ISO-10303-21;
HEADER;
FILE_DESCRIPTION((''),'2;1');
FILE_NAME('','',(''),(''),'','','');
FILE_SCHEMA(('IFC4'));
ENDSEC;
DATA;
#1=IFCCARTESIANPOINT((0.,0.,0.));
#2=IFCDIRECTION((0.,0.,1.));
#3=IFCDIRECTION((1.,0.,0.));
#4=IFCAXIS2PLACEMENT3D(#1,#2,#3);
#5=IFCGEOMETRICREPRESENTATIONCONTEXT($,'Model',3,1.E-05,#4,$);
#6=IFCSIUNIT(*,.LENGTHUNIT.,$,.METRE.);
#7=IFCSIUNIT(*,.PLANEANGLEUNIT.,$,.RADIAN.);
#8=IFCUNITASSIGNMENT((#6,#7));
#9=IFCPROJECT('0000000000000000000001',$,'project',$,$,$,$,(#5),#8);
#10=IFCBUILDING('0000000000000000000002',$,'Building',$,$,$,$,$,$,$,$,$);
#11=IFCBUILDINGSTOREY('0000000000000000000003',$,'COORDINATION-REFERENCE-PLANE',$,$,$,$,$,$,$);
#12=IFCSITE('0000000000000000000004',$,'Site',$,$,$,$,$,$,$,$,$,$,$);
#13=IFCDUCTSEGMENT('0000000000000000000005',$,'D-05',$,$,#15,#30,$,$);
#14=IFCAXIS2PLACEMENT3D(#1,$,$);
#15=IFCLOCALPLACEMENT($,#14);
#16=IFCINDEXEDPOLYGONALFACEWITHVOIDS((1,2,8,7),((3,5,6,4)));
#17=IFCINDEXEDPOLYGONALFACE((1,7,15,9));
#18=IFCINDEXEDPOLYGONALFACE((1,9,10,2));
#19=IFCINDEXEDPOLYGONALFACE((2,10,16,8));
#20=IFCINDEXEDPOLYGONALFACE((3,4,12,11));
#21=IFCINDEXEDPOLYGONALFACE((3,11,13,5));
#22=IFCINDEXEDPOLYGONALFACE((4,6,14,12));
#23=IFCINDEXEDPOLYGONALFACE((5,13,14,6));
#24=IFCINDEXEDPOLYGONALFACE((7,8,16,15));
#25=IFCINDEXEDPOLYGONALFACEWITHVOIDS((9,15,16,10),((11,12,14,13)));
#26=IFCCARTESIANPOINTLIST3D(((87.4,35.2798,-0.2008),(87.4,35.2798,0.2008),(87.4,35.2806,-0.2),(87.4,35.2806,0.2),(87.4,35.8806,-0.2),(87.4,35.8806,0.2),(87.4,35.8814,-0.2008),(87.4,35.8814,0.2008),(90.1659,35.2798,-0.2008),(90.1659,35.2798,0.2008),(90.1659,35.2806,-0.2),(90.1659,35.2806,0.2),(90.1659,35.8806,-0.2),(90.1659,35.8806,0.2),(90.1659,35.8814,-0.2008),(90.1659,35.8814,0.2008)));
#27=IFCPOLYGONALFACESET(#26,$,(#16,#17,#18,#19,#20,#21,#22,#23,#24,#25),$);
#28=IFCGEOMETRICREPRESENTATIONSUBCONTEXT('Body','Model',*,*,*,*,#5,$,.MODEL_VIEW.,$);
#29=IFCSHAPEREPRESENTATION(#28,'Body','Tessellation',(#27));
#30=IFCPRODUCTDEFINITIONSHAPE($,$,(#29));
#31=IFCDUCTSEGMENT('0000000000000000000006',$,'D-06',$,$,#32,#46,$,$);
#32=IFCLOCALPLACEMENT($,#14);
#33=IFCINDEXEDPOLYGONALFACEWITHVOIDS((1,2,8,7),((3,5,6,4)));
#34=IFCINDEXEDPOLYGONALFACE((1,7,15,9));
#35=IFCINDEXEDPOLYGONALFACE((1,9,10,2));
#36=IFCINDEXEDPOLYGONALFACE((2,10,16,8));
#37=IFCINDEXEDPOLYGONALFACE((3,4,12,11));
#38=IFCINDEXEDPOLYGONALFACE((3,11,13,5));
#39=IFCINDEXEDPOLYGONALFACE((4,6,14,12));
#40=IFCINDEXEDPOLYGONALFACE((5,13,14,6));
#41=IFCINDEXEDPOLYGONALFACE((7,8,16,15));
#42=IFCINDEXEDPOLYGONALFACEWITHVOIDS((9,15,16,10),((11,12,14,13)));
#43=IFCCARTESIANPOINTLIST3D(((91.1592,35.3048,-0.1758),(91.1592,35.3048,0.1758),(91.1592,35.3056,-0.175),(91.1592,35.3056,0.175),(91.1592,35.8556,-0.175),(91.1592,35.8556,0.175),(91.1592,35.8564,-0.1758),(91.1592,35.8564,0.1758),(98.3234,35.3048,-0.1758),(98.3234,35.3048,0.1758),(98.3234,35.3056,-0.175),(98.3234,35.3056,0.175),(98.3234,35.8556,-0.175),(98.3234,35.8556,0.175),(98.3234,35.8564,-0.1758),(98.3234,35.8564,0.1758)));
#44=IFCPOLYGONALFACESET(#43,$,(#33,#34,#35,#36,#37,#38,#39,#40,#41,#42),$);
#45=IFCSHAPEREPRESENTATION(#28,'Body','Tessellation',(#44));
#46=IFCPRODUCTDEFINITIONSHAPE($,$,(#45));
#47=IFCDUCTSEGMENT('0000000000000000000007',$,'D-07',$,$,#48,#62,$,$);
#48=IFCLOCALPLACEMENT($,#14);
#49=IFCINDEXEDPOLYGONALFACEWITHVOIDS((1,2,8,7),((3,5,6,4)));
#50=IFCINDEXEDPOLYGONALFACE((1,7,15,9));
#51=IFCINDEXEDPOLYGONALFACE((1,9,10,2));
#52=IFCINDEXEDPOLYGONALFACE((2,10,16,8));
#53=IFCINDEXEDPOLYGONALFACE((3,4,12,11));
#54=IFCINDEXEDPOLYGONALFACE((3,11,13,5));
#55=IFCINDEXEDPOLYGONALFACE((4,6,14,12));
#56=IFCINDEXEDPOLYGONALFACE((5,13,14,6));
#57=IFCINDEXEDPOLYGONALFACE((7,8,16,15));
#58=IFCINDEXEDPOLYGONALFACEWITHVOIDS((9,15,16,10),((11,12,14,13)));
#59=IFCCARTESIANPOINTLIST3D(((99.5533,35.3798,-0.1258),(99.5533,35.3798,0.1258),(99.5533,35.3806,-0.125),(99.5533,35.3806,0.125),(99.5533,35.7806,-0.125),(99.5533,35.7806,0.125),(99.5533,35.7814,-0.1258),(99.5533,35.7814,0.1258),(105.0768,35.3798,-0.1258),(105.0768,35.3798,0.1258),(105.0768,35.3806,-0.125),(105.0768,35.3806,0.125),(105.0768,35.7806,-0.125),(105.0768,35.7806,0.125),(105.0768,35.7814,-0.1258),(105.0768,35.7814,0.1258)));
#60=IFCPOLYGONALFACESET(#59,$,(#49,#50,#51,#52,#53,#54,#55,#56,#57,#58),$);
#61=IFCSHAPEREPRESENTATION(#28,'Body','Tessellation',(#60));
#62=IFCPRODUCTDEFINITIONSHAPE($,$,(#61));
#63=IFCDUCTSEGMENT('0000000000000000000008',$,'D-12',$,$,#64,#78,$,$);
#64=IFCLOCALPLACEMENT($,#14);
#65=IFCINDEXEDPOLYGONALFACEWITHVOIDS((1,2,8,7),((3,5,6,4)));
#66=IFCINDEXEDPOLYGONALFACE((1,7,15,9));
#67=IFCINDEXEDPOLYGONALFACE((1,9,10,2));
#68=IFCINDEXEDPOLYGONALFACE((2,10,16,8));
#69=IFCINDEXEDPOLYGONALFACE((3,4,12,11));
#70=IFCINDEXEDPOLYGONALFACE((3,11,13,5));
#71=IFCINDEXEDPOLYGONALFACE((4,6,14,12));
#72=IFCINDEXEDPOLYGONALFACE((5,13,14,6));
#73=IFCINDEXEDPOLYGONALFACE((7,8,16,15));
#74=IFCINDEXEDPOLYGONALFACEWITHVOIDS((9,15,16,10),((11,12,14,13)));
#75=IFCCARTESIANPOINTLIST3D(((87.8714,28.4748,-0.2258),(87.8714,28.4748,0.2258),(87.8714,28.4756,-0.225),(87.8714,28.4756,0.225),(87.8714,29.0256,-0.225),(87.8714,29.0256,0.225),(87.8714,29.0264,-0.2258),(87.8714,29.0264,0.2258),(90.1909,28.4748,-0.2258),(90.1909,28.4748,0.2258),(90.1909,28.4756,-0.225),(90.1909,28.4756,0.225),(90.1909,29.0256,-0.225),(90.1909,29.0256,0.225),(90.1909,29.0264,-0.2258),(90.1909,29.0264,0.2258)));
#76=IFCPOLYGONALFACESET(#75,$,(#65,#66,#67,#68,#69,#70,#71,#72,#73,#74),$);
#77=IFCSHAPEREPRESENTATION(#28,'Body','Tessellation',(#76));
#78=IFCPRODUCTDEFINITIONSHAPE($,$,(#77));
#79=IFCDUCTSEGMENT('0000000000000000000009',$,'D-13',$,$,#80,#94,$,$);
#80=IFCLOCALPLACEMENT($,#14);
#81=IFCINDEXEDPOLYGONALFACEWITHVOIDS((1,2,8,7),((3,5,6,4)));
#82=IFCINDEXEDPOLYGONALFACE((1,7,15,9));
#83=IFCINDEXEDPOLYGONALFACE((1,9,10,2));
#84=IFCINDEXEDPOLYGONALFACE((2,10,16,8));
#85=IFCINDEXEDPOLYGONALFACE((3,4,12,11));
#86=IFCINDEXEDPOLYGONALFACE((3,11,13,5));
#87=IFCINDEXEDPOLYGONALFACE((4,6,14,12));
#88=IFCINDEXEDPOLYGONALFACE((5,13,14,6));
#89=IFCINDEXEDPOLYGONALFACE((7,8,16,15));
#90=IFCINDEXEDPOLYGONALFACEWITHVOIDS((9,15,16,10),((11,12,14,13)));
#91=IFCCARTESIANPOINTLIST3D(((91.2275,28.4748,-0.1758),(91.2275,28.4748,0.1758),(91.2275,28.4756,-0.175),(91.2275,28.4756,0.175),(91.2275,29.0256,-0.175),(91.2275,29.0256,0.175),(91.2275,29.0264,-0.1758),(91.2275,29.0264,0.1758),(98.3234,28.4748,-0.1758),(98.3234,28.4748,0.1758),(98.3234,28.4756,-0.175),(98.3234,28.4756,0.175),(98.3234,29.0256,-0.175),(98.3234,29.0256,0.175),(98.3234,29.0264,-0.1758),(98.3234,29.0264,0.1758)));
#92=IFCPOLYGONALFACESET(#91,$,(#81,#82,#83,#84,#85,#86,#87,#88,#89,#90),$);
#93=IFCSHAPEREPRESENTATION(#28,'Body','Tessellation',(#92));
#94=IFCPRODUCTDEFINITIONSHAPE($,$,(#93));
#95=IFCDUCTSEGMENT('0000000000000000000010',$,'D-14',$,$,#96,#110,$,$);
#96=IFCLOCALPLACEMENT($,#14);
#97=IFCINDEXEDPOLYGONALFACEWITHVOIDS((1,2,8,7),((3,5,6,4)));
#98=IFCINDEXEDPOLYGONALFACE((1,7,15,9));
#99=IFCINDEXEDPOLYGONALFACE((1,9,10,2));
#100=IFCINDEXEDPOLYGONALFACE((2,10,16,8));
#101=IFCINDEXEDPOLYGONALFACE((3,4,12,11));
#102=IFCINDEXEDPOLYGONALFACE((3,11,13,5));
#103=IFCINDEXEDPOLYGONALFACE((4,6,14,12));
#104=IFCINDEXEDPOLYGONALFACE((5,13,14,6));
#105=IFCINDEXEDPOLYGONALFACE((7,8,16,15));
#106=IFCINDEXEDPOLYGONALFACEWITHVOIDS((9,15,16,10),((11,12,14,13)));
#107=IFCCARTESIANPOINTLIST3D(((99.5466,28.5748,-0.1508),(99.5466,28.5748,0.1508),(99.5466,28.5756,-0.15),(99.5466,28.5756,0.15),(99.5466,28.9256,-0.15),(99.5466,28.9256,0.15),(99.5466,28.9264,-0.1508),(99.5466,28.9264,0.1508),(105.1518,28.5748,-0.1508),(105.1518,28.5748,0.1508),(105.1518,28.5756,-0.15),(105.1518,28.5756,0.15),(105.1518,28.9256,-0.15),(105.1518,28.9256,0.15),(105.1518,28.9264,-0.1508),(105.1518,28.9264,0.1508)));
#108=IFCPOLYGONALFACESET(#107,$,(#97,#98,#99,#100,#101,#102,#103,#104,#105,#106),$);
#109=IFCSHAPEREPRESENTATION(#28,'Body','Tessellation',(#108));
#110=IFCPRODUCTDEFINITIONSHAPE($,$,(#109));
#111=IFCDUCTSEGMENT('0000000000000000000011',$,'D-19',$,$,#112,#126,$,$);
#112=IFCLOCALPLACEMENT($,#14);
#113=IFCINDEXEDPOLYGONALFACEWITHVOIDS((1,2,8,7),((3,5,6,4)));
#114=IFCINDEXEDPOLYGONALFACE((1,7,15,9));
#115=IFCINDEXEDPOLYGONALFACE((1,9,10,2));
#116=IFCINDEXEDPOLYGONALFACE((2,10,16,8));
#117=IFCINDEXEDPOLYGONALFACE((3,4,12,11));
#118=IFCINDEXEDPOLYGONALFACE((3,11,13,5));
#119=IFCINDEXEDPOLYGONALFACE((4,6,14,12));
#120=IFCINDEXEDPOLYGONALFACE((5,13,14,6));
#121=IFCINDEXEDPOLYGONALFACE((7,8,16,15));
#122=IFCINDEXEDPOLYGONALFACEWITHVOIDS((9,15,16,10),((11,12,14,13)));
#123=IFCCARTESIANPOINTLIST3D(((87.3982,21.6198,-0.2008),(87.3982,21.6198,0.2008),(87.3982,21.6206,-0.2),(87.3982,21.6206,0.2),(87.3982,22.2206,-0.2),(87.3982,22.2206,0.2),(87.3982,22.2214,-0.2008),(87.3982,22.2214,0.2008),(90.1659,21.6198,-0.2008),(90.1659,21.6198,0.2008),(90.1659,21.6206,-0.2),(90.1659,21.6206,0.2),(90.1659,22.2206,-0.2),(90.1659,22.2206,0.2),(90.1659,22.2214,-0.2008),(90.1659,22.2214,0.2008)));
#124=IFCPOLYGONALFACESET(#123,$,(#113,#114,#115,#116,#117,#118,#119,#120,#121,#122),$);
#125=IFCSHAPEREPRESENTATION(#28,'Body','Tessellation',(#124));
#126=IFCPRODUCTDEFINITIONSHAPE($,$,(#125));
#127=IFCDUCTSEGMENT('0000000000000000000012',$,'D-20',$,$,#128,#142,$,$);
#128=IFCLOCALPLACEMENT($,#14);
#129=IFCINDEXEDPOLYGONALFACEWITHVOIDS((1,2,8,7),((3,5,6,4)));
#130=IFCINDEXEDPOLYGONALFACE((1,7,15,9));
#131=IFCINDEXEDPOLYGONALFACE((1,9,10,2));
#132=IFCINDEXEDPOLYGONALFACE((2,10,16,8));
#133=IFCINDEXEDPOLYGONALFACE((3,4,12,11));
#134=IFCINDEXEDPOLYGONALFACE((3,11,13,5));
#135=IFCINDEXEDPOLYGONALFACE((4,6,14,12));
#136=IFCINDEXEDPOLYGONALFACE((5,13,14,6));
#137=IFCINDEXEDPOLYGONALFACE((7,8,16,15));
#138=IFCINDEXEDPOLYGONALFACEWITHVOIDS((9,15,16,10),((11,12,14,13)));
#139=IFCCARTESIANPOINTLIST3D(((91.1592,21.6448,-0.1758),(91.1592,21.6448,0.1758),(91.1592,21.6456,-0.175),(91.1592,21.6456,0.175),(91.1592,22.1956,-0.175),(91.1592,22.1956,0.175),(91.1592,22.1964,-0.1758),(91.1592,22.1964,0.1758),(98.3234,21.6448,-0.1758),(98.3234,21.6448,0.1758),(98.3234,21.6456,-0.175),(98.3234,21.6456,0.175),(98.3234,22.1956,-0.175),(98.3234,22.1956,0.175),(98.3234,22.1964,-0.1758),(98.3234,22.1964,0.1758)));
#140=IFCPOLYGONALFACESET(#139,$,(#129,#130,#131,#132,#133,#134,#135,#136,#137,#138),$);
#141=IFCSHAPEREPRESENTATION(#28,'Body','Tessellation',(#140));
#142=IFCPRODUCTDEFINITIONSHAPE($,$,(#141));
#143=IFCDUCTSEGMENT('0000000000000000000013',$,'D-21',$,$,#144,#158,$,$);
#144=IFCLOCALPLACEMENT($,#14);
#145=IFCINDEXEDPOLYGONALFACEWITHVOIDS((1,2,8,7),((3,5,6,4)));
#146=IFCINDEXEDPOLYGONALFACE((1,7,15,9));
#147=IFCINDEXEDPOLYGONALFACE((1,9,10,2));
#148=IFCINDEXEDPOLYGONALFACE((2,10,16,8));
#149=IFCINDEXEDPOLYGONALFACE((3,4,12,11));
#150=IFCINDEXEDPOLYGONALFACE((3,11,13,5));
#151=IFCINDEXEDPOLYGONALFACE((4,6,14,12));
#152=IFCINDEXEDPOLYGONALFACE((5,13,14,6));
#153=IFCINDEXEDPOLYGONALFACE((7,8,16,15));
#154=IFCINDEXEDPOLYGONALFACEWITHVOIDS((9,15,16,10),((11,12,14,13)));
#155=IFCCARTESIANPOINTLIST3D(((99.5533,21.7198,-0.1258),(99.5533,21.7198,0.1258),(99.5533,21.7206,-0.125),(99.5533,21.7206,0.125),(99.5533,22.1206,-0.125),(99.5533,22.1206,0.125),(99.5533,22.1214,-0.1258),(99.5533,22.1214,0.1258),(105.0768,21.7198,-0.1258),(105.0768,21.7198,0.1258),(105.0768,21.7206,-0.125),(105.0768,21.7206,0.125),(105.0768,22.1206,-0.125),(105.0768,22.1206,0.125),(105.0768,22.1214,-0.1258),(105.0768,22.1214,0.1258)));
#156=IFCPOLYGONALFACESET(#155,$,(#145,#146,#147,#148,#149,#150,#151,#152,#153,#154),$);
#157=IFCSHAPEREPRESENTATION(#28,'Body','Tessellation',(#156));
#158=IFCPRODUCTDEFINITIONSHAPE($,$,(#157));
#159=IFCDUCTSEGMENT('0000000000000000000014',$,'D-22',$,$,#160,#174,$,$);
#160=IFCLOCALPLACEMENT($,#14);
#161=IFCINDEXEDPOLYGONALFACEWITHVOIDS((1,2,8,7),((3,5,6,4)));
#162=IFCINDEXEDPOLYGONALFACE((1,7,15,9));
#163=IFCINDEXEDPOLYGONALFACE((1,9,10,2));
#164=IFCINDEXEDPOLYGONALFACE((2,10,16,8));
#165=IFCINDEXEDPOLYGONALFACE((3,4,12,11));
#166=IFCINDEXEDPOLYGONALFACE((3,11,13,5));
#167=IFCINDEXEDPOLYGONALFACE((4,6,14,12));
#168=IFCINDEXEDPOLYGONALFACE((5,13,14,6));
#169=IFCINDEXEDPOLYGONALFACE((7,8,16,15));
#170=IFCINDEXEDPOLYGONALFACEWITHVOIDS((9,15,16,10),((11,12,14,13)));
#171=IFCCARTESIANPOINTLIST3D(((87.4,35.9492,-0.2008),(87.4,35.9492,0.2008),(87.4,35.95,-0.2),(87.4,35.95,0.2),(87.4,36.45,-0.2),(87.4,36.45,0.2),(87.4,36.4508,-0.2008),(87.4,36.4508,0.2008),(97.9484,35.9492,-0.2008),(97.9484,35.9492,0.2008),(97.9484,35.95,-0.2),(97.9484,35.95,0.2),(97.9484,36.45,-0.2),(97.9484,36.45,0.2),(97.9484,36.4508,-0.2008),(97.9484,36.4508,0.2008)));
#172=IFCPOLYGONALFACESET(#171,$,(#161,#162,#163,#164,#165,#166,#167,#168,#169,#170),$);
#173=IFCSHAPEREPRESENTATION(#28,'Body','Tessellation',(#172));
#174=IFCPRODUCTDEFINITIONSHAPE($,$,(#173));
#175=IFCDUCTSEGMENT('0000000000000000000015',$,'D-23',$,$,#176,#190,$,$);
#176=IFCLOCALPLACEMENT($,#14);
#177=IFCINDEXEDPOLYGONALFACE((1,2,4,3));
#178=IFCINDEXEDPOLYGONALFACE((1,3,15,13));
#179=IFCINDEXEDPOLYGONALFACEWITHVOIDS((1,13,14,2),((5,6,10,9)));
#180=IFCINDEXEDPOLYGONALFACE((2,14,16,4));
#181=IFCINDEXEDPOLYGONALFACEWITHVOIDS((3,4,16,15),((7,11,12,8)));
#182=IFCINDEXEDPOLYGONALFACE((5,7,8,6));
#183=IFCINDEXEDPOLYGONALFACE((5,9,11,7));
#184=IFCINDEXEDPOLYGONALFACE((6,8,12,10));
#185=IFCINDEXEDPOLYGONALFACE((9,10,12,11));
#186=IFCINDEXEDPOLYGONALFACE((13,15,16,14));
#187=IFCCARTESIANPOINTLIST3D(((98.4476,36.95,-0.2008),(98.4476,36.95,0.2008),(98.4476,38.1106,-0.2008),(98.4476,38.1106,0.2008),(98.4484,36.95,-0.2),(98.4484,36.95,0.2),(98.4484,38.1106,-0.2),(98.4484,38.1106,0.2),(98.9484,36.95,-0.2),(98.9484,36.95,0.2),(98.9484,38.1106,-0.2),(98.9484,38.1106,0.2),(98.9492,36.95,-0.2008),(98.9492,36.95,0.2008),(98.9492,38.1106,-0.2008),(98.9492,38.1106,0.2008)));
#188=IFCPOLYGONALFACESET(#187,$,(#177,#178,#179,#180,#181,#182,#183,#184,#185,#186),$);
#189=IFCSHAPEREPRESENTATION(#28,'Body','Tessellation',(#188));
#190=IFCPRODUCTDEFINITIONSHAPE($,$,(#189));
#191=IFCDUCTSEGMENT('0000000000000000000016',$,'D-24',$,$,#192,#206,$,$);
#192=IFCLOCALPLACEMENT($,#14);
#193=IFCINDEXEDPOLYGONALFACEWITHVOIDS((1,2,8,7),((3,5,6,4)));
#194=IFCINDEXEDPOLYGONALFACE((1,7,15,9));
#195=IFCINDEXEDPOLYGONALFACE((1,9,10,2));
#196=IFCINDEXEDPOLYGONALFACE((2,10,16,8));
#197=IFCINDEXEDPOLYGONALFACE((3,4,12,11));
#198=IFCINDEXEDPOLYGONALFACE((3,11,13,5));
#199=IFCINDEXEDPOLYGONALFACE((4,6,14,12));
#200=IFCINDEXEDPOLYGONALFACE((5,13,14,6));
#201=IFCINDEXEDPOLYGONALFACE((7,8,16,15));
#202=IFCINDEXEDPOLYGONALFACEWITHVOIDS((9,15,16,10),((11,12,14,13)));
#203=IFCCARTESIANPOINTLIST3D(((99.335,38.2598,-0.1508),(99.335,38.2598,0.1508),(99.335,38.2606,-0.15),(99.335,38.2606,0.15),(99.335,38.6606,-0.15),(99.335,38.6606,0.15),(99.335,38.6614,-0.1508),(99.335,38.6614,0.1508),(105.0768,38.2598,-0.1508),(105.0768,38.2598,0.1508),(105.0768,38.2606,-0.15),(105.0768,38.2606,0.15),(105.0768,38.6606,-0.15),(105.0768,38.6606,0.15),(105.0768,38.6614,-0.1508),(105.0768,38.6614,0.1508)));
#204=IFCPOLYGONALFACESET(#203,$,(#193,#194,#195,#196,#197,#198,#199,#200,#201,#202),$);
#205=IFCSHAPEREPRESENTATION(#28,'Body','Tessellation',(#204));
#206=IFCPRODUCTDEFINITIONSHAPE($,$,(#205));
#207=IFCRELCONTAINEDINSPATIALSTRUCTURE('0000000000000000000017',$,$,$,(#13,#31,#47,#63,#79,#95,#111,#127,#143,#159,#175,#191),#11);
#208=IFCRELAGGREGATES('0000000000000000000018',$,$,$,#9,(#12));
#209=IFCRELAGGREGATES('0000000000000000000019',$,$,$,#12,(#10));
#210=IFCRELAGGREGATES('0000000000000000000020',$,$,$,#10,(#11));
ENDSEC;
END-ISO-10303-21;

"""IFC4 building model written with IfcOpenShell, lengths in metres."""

from ifc_helpers import new_model, si_unit, frame, origin, origin_with_axes, place, context, subcontext, project, spatial, hollow_rectangle, extrude, element, save


model = new_model("IFC4")

# Units and contexts
model_context = context("Model", 3, precision=1e-05, world=origin_with_axes())
body_context = subcontext(model_context, "Body", "Model", "MODEL_VIEW")
ifc_project = project(units=[si_unit("LENGTHUNIT", "METRE"), si_unit("PLANEANGLEUNIT", "RADIAN")], contexts=[model_context])

# Site, building, storey
site = spatial("IfcSite", under=ifc_project, Name="Site")
building = spatial("IfcBuilding", under=site, Name="Building")
storey = spatial("IfcBuildingStorey", under=building, Name="COORDINATION-REFERENCE-PLANE")

# Duct segments
duct_segment_1_placement = place(None, frame((87.4, 35.5806, 0.0), z_axis=(1.0, 0.0, 0.0), x_axis=(0.0, 1.0, 0.0)))
element("IfcDuctSegment", 1, at=duct_segment_1_placement, inside=storey, Name="D-05", context=body_context, shape_type="SweptSolid", body=[
    extrude(hollow_rectangle(XDim=0.6016, YDim=0.4016, WallThickness=0.0008), origin(), (0.0, 0.0, 1.0), 2.7659),
])
duct_segment_2_placement = place(None, frame((91.1592, 35.5806, 0.0), z_axis=(1.0, 0.0, 0.0), x_axis=(0.0, 1.0, 0.0)))
element("IfcDuctSegment", 2, at=duct_segment_2_placement, inside=storey, Name="D-06", context=body_context, shape_type="SweptSolid", body=[
    extrude(hollow_rectangle(XDim=0.5516, YDim=0.3516, WallThickness=0.0008), origin(), (0.0, 0.0, 1.0), 7.1642),
])
duct_segment_3_placement = place(None, frame((99.5533, 35.5806, 0.0), z_axis=(1.0, 0.0, 0.0), x_axis=(0.0, 1.0, 0.0)))
element("IfcDuctSegment", 3, at=duct_segment_3_placement, inside=storey, Name="D-07", context=body_context, shape_type="SweptSolid", body=[
    extrude(hollow_rectangle(XDim=0.4016, YDim=0.2516, WallThickness=0.0008), origin(), (0.0, 0.0, 1.0), 5.5234),
])
duct_segment_4_placement = place(None, frame((87.8714, 28.7506, 0.0), z_axis=(1.0, 0.0, 0.0), x_axis=(0.0, 1.0, 0.0)))
element("IfcDuctSegment", 4, at=duct_segment_4_placement, inside=storey, Name="D-12", context=body_context, shape_type="SweptSolid", body=[
    extrude(hollow_rectangle(XDim=0.5516, YDim=0.4516, WallThickness=0.0008), origin(), (0.0, 0.0, 1.0), 2.3195),
])
duct_segment_5_placement = place(None, frame((91.2275, 28.7506, 0.0), z_axis=(1.0, 0.0, 0.0), x_axis=(0.0, 1.0, 0.0)))
element("IfcDuctSegment", 5, at=duct_segment_5_placement, inside=storey, Name="D-13", context=body_context, shape_type="SweptSolid", body=[
    extrude(hollow_rectangle(XDim=0.5516, YDim=0.3516, WallThickness=0.0008), origin(), (0.0, 0.0, 1.0), 7.0959),
])
duct_segment_6_placement = place(None, frame((99.5466, 28.7506, 0.0), z_axis=(1.0, 0.0, 0.0), x_axis=(0.0, 1.0, 0.0)))
element("IfcDuctSegment", 6, at=duct_segment_6_placement, inside=storey, Name="D-14", context=body_context, shape_type="SweptSolid", body=[
    extrude(hollow_rectangle(XDim=0.3516, YDim=0.3016, WallThickness=0.0008), origin(), (0.0, 0.0, 1.0), 5.6051),
])
duct_segment_7_placement = place(None, frame((87.3982, 21.9206, 0.0), z_axis=(1.0, 0.0, 0.0), x_axis=(0.0, 1.0, 0.0)))
element("IfcDuctSegment", 7, at=duct_segment_7_placement, inside=storey, Name="D-19", context=body_context, shape_type="SweptSolid", body=[
    extrude(hollow_rectangle(XDim=0.6016, YDim=0.4016, WallThickness=0.0008), origin(), (0.0, 0.0, 1.0), 2.7677),
])
duct_segment_8_placement = place(None, frame((91.1592, 21.9206, 0.0), z_axis=(1.0, 0.0, 0.0), x_axis=(0.0, 1.0, 0.0)))
element("IfcDuctSegment", 8, at=duct_segment_8_placement, inside=storey, Name="D-20", context=body_context, shape_type="SweptSolid", body=[
    extrude(hollow_rectangle(XDim=0.5516, YDim=0.3516, WallThickness=0.0008), origin(), (0.0, 0.0, 1.0), 7.1642),
])
duct_segment_9_placement = place(None, frame((99.5533, 21.9206, 0.0), z_axis=(1.0, 0.0, 0.0), x_axis=(0.0, 1.0, 0.0)))
element("IfcDuctSegment", 9, at=duct_segment_9_placement, inside=storey, Name="D-21", context=body_context, shape_type="SweptSolid", body=[
    extrude(hollow_rectangle(XDim=0.4016, YDim=0.2516, WallThickness=0.0008), origin(), (0.0, 0.0, 1.0), 5.5234),
])
duct_segment_10_placement = place(None, frame((87.4, 36.2, 0.0), z_axis=(1.0, 0.0, 0.0), x_axis=(0.0, 1.0, 0.0)))
element("IfcDuctSegment", 10, at=duct_segment_10_placement, inside=storey, Name="D-22", context=body_context, shape_type="SweptSolid", body=[
    extrude(hollow_rectangle(XDim=0.5016, YDim=0.4016, WallThickness=0.0008), origin(), (0.0, 0.0, 1.0), 10.5484),
])
duct_segment_11_placement = place(None, frame((98.6984, 36.95, 0.0), z_axis=(0.0, 1.0, 0.0), x_axis=(1.0, 0.0, 0.0)))
element("IfcDuctSegment", 11, at=duct_segment_11_placement, inside=storey, Name="D-23", context=body_context, shape_type="SweptSolid", body=[
    extrude(hollow_rectangle(XDim=0.5016, YDim=0.4016, WallThickness=0.0008), origin(), (0.0, 0.0, 1.0), 1.1606),
])
duct_segment_12_placement = place(None, frame((99.335, 38.4606, 0.0), z_axis=(1.0, 0.0, 0.0), x_axis=(0.0, 1.0, 0.0)))
element("IfcDuctSegment", 12, at=duct_segment_12_placement, inside=storey, Name="D-24", context=body_context, shape_type="SweptSolid", body=[
    extrude(hollow_rectangle(XDim=0.4016, YDim=0.3016, WallThickness=0.0008), origin(), (0.0, 0.0, 1.0), 5.7417),
])

save(model, "model.ifc")
